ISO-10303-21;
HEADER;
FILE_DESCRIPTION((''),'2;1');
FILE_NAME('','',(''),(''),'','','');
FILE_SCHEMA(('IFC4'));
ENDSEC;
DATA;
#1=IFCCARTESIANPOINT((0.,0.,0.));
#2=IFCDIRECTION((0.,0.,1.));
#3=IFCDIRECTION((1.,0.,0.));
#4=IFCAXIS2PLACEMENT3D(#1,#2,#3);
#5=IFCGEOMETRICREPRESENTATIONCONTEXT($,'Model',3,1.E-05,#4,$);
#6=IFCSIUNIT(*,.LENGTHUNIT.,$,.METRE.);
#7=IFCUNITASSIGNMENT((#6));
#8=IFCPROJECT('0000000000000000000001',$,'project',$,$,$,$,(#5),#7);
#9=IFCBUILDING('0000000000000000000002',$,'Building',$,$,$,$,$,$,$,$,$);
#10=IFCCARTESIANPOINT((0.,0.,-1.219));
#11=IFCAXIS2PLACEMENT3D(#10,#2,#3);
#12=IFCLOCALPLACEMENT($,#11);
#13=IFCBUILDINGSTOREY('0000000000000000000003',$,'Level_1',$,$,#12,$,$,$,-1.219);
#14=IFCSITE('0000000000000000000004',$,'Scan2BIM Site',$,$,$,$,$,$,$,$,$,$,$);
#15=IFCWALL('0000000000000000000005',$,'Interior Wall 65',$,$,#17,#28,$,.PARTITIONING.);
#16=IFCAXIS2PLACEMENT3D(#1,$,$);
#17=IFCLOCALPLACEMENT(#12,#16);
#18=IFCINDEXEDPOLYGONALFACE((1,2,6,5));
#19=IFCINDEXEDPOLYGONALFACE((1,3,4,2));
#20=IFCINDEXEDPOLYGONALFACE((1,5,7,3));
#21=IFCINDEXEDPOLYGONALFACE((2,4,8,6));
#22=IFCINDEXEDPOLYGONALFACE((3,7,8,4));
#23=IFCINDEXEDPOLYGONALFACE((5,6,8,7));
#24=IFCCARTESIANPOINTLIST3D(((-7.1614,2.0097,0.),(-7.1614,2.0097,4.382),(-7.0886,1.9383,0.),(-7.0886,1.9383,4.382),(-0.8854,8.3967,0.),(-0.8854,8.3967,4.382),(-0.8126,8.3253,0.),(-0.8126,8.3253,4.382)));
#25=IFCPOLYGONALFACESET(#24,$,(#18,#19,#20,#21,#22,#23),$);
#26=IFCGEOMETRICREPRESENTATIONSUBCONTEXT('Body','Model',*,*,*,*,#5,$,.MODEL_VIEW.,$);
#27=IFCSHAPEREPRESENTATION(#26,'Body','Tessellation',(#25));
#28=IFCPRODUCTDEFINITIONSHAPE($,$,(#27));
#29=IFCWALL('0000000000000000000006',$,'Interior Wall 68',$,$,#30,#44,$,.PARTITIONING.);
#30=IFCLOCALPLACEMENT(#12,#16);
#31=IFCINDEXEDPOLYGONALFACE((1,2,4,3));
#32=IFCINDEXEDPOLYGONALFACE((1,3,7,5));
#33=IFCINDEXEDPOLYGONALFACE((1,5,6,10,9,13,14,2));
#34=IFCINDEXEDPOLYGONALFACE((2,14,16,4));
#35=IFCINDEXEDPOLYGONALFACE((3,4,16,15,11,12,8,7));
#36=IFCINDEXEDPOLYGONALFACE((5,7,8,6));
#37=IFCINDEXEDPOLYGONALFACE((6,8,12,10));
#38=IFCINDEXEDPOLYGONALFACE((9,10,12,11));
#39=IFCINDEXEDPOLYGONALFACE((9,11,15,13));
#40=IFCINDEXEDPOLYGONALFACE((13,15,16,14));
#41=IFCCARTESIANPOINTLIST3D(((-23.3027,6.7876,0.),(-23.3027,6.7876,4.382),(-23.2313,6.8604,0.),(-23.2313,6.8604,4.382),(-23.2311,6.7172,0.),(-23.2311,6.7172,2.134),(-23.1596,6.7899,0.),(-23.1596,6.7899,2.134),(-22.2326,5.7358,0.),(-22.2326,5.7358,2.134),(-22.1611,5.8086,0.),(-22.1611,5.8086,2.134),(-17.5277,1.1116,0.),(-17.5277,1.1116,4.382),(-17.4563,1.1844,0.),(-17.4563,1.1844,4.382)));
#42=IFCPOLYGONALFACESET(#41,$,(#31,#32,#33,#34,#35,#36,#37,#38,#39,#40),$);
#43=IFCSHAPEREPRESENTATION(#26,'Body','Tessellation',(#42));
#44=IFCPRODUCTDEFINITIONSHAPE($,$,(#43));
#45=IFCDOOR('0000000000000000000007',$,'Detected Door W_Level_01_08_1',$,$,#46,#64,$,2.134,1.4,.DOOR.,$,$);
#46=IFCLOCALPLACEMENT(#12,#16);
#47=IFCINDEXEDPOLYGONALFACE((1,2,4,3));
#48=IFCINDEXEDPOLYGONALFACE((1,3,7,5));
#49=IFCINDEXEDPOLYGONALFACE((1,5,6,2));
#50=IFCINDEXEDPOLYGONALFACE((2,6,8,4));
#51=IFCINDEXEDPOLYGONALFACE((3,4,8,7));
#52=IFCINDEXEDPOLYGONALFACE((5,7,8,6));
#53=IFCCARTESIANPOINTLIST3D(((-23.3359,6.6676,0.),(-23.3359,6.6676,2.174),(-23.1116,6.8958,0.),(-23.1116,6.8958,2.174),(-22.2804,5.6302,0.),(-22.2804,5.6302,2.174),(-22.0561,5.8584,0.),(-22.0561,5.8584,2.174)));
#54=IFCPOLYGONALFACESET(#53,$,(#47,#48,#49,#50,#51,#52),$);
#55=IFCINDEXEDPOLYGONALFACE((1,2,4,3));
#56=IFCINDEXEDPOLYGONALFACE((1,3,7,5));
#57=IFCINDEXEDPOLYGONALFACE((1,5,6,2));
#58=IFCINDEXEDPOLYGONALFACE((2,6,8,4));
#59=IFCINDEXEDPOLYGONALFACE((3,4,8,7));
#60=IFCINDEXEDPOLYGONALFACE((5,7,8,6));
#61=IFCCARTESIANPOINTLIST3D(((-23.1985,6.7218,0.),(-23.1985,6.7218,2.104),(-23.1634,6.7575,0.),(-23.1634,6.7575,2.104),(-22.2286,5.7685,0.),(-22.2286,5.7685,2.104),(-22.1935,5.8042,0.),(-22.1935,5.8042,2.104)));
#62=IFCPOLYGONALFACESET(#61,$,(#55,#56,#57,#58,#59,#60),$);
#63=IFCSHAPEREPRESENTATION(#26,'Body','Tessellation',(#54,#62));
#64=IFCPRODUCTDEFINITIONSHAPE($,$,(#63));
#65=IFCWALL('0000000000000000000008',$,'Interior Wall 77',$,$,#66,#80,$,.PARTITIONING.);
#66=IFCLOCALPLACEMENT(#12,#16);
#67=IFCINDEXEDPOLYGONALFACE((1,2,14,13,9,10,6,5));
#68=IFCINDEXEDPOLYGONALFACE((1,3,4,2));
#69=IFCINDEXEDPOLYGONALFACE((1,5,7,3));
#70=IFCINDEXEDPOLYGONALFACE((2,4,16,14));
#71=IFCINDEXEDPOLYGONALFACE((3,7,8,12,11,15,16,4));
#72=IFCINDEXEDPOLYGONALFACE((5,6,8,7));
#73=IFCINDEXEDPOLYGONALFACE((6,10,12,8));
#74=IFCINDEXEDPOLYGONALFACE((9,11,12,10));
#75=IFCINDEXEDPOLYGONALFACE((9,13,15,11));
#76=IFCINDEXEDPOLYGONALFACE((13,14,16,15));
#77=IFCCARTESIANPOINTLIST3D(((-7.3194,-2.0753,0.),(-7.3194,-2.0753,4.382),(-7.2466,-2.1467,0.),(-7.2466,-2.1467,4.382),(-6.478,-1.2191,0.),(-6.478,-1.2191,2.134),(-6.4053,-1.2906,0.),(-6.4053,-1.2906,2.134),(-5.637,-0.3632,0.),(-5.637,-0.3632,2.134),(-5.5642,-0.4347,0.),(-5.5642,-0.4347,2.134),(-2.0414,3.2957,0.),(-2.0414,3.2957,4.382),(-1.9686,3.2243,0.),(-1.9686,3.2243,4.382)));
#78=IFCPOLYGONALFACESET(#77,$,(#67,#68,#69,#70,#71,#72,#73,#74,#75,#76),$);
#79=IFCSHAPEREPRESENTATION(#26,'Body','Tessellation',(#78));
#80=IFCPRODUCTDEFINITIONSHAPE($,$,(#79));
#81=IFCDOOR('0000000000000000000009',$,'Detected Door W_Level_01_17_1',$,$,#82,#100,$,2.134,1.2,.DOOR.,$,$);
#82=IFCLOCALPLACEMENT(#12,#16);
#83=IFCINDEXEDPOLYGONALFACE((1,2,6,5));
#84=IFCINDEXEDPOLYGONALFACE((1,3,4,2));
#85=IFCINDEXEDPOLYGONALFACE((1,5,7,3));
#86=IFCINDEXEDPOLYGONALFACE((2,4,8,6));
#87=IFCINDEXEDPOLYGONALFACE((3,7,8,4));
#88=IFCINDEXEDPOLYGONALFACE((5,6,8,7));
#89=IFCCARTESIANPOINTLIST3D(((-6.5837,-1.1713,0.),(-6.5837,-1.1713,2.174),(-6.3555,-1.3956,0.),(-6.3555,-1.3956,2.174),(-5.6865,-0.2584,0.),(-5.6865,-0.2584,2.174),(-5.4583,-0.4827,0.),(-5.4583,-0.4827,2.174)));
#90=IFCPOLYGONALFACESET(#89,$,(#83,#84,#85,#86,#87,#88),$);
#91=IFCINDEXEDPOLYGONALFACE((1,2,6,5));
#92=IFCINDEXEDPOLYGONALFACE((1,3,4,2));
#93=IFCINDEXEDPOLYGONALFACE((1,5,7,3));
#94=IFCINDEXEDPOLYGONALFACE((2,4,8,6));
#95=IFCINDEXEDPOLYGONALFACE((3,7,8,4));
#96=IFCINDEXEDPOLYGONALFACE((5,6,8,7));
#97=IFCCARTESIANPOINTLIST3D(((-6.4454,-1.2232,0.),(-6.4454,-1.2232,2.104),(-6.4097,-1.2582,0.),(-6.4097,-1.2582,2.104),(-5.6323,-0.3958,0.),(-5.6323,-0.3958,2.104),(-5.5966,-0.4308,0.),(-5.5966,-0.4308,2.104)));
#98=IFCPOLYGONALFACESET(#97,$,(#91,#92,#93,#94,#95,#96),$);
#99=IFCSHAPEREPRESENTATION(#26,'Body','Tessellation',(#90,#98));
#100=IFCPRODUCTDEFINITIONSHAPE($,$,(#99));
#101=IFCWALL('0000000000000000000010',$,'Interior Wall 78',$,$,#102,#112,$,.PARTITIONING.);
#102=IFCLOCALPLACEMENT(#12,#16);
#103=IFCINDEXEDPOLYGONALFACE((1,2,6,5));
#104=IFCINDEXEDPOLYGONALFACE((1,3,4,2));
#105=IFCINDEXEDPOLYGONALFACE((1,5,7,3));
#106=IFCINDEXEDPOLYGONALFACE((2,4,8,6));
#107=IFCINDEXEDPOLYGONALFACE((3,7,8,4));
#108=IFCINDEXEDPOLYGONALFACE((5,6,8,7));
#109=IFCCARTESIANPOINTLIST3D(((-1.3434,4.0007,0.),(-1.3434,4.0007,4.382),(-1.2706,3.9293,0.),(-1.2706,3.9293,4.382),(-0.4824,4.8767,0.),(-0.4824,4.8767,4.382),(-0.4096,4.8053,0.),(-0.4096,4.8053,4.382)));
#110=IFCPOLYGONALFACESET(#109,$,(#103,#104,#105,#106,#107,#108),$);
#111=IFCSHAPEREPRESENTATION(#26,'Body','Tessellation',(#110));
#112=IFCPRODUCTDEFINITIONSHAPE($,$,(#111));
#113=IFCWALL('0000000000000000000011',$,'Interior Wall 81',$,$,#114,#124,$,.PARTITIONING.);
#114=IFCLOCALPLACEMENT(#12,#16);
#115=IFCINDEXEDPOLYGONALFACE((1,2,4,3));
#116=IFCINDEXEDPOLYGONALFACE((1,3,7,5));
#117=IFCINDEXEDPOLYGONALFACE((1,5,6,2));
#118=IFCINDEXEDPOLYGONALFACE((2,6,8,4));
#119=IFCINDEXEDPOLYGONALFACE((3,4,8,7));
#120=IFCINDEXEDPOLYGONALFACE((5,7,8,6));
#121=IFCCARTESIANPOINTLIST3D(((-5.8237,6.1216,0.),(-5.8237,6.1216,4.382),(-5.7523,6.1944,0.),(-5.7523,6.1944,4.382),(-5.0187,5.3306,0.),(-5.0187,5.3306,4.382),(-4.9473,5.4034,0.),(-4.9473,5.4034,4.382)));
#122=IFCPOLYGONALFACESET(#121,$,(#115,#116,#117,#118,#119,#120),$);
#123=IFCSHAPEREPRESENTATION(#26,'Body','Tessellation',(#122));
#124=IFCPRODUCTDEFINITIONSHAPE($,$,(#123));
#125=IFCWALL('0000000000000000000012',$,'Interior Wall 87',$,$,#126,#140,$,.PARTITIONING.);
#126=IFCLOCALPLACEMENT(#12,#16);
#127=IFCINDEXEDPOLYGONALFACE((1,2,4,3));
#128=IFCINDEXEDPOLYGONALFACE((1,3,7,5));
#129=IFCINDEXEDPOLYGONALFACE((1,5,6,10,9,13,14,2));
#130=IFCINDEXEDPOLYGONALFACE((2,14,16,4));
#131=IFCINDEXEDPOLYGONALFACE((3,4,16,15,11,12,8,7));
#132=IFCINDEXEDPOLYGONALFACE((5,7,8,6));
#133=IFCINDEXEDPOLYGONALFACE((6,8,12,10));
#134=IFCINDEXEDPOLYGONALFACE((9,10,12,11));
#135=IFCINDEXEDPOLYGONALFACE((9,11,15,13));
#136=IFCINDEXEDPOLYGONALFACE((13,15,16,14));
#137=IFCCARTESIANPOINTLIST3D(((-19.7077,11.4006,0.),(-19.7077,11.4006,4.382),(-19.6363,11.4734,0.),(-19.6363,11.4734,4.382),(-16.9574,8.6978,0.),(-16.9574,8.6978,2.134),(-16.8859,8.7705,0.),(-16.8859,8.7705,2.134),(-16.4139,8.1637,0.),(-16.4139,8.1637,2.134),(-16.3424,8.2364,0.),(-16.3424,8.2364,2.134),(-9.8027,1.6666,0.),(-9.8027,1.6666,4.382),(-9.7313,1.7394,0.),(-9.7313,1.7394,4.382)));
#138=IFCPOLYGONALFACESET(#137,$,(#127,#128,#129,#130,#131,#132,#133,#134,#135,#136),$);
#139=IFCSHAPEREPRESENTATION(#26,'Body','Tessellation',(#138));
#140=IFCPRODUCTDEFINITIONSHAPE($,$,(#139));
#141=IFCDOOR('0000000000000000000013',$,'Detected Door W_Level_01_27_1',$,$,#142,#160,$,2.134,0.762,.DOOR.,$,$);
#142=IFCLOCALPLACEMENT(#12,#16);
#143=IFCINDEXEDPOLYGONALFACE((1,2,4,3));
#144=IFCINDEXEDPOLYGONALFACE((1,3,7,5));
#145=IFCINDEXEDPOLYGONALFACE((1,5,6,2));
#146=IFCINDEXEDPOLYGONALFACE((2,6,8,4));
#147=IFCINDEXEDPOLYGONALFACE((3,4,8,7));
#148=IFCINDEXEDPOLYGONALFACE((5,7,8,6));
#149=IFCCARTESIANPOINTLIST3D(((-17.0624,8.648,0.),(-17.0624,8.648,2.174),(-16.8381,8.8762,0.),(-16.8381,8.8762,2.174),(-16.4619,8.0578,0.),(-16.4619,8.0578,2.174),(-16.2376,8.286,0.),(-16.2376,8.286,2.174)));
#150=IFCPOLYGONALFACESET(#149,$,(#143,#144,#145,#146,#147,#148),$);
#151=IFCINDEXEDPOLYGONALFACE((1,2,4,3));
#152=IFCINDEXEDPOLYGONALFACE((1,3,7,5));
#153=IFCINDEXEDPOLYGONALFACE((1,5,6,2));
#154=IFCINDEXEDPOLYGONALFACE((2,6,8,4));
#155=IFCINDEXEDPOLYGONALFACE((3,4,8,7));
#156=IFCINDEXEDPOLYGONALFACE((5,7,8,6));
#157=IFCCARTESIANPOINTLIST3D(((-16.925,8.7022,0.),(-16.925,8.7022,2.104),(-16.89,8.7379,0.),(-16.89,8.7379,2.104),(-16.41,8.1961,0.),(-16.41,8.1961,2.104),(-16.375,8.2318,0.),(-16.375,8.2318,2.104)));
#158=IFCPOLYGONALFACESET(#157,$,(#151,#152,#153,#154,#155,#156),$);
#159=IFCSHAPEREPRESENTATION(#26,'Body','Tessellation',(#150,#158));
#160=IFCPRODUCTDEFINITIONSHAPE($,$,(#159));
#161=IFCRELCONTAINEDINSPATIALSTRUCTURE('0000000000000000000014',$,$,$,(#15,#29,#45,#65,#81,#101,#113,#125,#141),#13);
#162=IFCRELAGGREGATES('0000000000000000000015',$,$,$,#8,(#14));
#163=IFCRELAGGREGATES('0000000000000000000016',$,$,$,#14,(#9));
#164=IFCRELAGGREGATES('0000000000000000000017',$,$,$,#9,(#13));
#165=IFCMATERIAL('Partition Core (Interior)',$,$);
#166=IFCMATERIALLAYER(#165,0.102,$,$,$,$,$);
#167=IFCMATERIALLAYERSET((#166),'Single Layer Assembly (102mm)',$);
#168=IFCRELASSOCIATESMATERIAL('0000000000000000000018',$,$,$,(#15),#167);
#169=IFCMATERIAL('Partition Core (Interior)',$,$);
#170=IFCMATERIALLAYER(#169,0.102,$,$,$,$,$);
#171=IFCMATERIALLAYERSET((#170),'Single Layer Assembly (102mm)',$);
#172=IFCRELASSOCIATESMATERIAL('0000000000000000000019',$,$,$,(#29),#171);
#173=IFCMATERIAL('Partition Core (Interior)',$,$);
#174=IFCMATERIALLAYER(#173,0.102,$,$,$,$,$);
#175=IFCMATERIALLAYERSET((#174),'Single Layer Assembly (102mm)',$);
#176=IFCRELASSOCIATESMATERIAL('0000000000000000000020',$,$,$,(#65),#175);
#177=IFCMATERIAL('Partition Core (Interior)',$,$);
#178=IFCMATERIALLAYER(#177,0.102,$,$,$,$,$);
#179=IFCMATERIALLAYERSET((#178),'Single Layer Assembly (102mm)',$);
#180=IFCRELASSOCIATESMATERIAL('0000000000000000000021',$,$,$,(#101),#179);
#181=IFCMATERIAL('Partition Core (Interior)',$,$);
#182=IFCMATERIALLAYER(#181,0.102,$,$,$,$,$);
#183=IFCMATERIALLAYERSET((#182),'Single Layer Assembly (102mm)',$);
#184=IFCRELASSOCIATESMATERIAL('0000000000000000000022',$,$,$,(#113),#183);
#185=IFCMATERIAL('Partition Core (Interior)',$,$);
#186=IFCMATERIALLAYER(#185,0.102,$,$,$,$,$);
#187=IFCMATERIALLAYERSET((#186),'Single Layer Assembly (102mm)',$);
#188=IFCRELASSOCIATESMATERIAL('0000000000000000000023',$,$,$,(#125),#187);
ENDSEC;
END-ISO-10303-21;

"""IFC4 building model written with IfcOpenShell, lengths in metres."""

from ifc_helpers import new_model, si_unit, frame, origin, origin_with_axes, place, context, subcontext, project, spatial, rectangle, extrude, material, layer, layer_set, element, fill, save


model = new_model("IFC4")

# Units and contexts
model_context = context("Model", 3, precision=1e-05, world=origin_with_axes())
body_context = subcontext(model_context, "Body", "Model", "MODEL_VIEW")
ifc_project = project(units=[si_unit("LENGTHUNIT", "METRE")], contexts=[model_context])

# Site, building, storey
site = spatial("IfcSite", under=ifc_project, Name="Scan2BIM Site")
building = spatial("IfcBuilding", under=site, Name="Building")
storey_placement = place(None, frame((0.0, 0.0, -1.219), z_axis=(0.0, 0.0, 1.0), x_axis=(1.0, 0.0, 0.0)))
storey = spatial("IfcBuildingStorey", under=building, at=storey_placement, Name="Level_1", Elevation=-1.219)

# Wall
ifc_material_1 = material(Name="Partition Core (Interior)")
ifc_layer_1 = layer(ifc_material_1, 0.102)
ifc_layer_set_1 = layer_set([ifc_layer_1], Name="Single Layer Assembly (102mm)")
wall_1_placement = place(storey_placement, frame((-3.987, 5.1675, 0.0), z_axis=(0.0, 0.0, 1.0), x_axis=(-0.700882, -0.713278, 0.0)))
element("IfcWall", 1, at=wall_1_placement, inside=storey, material=ifc_layer_set_1, Name="Interior Wall 65", PredefinedType="PARTITIONING", context=body_context, shape_type="SweptSolid", body=[
    extrude(rectangle(XDim=8.9544, YDim=0.102), origin(), (0.0, 0.0, 1.0), 4.382),
])

# Walls, openings, doors
ifc_material_2 = material(Name="Partition Core (Interior)")
ifc_layer_2 = layer(ifc_material_2, 0.102)
ifc_layer_set_2 = layer_set([ifc_layer_2], Name="Single Layer Assembly (102mm)")
wall_2_placement = place(storey_placement, frame((-20.3795, 3.986, 0.0), z_axis=(0.0, 0.0, 1.0), x_axis=(0.713193, -0.700967, 0.0)))
wall_2 = element("IfcWall", 2, at=wall_2_placement, inside=storey, material=ifc_layer_set_2, Name="Interior Wall 68", PredefinedType="PARTITIONING", context=body_context, shape_type="SweptSolid", body=[
    extrude(rectangle(XDim=8.0974, YDim=0.102), origin(), (0.0, 0.0, 1.0), 4.382),
])
opening_1_placement = place(None, frame((-22.696, 6.263, -1.219), z_axis=(0.0, 0.0, 1.0), x_axis=(0.713193, -0.700967, 0.0)))
opening_1 = element("IfcOpeningElement", 3, at=opening_1_placement, cuts=wall_2, PredefinedType="OPENING", context=body_context, shape_type="SweptSolid", body=[
    extrude(rectangle(XDim=1.4, YDim=0.202), origin(), (0.0, 0.0, 1.0), 2.134),
])
door_1_placement = place(opening_1_placement, frame((0.0, 0.0, 0.0), z_axis=(0.0, 0.0, 1.0), x_axis=(1.0, 0.0, 0.0)))
door_1 = element("IfcDoor", 4, at=door_1_placement, inside=storey, Name="Detected Door W_Level_01_08_1", OverallHeight=2.134, OverallWidth=1.4, PredefinedType="DOOR", context=body_context, shape_type="SweptSolid", body=[
    extrude(rectangle(XDim=1.48, YDim=0.32), origin(), (0.0, 0.0, 1.0), 2.174),
    extrude(rectangle(XDim=1.36, YDim=0.05), origin(), (0.0, 0.0, 1.0), 2.104),
])
fill(opening_1, door_1)
ifc_material_3 = material(Name="Partition Core (Interior)")
ifc_layer_3 = layer(ifc_material_3, 0.102)
ifc_layer_set_3 = layer_set([ifc_layer_3], Name="Single Layer Assembly (102mm)")
wall_3_placement = place(storey_placement, frame((-4.644, 0.5745, 0.0), z_axis=(0.0, 0.0, 1.0), x_axis=(0.700905, 0.713255, 0.0)))
wall_3 = element("IfcWall", 5, at=wall_3_placement, inside=storey, material=ifc_layer_set_3, Name="Interior Wall 77", PredefinedType="PARTITIONING", context=body_context, shape_type="SweptSolid", body=[
    extrude(rectangle(XDim=7.5303, YDim=0.102), origin(), (0.0, 0.0, 1.0), 4.382),
])
opening_2_placement = place(None, frame((-6.021, -0.827, -1.219), z_axis=(0.0, 0.0, 1.0), x_axis=(0.700905, 0.713255, 0.0)))
opening_2 = element("IfcOpeningElement", 6, at=opening_2_placement, cuts=wall_3, PredefinedType="OPENING", context=body_context, shape_type="SweptSolid", body=[
    extrude(rectangle(XDim=1.2, YDim=0.202), origin(), (0.0, 0.0, 1.0), 2.134),
])
door_2_placement = place(opening_2_placement, frame((0.0, 0.0, 0.0), z_axis=(0.0, 0.0, 1.0), x_axis=(1.0, 0.0, 0.0)))
door_2 = element("IfcDoor", 7, at=door_2_placement, inside=storey, Name="Detected Door W_Level_01_17_1", OverallHeight=2.134, OverallWidth=1.2, PredefinedType="DOOR", context=body_context, shape_type="SweptSolid", body=[
    extrude(rectangle(XDim=1.28, YDim=0.32), origin(), (0.0, 0.0, 1.0), 2.174),
    extrude(rectangle(XDim=1.16, YDim=0.05), origin(), (0.0, 0.0, 1.0), 2.104),
])
fill(opening_2, door_2)

# Walls
ifc_material_4 = material(Name="Partition Core (Interior)")
ifc_layer_4 = layer(ifc_material_4, 0.102)
ifc_layer_set_4 = layer_set([ifc_layer_4], Name="Single Layer Assembly (102mm)")
wall_4_placement = place(storey_placement, frame((-0.8765, 4.403, 0.0), z_axis=(0.0, 0.0, 1.0), x_axis=(0.700974, 0.713186, 0.0)))
element("IfcWall", 8, at=wall_4_placement, inside=storey, material=ifc_layer_set_4, Name="Interior Wall 78", PredefinedType="PARTITIONING", context=body_context, shape_type="SweptSolid", body=[
    extrude(rectangle(XDim=1.2283, YDim=0.102), origin(), (0.0, 0.0, 1.0), 4.382),
])
ifc_material_5 = material(Name="Partition Core (Interior)")
ifc_layer_5 = layer(ifc_material_5, 0.102)
ifc_layer_set_5 = layer_set([ifc_layer_5], Name="Single Layer Assembly (102mm)")
wall_5_placement = place(storey_placement, frame((-5.3855, 5.7625, 0.0), z_axis=(0.0, 0.0, 1.0), x_axis=(0.713282, -0.700877, 0.0)))
element("IfcWall", 9, at=wall_5_placement, inside=storey, material=ifc_layer_set_5, Name="Interior Wall 81", PredefinedType="PARTITIONING", context=body_context, shape_type="SweptSolid", body=[
    extrude(rectangle(XDim=1.1286, YDim=0.102), origin(), (0.0, 0.0, 1.0), 4.382),
])

# Wall, opening, door
ifc_material_6 = material(Name="Partition Core (Interior)")
ifc_layer_6 = layer(ifc_material_6, 0.102)
ifc_layer_set_6 = layer_set([ifc_layer_6], Name="Single Layer Assembly (102mm)")
wall_6_placement = place(storey_placement, frame((-14.7195, 6.57, 0.0), z_axis=(0.0, 0.0, 1.0), x_axis=(-0.713237, 0.700923, 0.0)))
wall_6 = element("IfcWall", 10, at=wall_6_placement, inside=storey, material=ifc_layer_set_6, Name="Interior Wall 87", PredefinedType="PARTITIONING", context=body_context, shape_type="SweptSolid", body=[
    extrude(rectangle(XDim=13.8874, YDim=0.102), origin(), (0.0, 0.0, 1.0), 4.382),
])
opening_3_placement = place(None, frame((-16.65, 8.467, -1.219), z_axis=(0.0, 0.0, 1.0), x_axis=(-0.713237, 0.700923, 0.0)))
opening_3 = element("IfcOpeningElement", 11, at=opening_3_placement, cuts=wall_6, PredefinedType="OPENING", context=body_context, shape_type="SweptSolid", body=[
    extrude(rectangle(XDim=0.762, YDim=0.202), origin(), (0.0, 0.0, 1.0), 2.134),
])
door_3_placement = place(opening_3_placement, frame((0.0, 0.0, 0.0), z_axis=(0.0, 0.0, 1.0), x_axis=(1.0, 0.0, 0.0)))
door_3 = element("IfcDoor", 12, at=door_3_placement, inside=storey, Name="Detected Door W_Level_01_27_1", OverallHeight=2.134, OverallWidth=0.762, PredefinedType="DOOR", context=body_context, shape_type="SweptSolid", body=[
    extrude(rectangle(XDim=0.842, YDim=0.32), origin(), (0.0, 0.0, 1.0), 2.174),
    extrude(rectangle(XDim=0.722, YDim=0.05), origin(), (0.0, 0.0, 1.0), 2.104),
])
fill(opening_3, door_3)

save(model, "model.ifc")
